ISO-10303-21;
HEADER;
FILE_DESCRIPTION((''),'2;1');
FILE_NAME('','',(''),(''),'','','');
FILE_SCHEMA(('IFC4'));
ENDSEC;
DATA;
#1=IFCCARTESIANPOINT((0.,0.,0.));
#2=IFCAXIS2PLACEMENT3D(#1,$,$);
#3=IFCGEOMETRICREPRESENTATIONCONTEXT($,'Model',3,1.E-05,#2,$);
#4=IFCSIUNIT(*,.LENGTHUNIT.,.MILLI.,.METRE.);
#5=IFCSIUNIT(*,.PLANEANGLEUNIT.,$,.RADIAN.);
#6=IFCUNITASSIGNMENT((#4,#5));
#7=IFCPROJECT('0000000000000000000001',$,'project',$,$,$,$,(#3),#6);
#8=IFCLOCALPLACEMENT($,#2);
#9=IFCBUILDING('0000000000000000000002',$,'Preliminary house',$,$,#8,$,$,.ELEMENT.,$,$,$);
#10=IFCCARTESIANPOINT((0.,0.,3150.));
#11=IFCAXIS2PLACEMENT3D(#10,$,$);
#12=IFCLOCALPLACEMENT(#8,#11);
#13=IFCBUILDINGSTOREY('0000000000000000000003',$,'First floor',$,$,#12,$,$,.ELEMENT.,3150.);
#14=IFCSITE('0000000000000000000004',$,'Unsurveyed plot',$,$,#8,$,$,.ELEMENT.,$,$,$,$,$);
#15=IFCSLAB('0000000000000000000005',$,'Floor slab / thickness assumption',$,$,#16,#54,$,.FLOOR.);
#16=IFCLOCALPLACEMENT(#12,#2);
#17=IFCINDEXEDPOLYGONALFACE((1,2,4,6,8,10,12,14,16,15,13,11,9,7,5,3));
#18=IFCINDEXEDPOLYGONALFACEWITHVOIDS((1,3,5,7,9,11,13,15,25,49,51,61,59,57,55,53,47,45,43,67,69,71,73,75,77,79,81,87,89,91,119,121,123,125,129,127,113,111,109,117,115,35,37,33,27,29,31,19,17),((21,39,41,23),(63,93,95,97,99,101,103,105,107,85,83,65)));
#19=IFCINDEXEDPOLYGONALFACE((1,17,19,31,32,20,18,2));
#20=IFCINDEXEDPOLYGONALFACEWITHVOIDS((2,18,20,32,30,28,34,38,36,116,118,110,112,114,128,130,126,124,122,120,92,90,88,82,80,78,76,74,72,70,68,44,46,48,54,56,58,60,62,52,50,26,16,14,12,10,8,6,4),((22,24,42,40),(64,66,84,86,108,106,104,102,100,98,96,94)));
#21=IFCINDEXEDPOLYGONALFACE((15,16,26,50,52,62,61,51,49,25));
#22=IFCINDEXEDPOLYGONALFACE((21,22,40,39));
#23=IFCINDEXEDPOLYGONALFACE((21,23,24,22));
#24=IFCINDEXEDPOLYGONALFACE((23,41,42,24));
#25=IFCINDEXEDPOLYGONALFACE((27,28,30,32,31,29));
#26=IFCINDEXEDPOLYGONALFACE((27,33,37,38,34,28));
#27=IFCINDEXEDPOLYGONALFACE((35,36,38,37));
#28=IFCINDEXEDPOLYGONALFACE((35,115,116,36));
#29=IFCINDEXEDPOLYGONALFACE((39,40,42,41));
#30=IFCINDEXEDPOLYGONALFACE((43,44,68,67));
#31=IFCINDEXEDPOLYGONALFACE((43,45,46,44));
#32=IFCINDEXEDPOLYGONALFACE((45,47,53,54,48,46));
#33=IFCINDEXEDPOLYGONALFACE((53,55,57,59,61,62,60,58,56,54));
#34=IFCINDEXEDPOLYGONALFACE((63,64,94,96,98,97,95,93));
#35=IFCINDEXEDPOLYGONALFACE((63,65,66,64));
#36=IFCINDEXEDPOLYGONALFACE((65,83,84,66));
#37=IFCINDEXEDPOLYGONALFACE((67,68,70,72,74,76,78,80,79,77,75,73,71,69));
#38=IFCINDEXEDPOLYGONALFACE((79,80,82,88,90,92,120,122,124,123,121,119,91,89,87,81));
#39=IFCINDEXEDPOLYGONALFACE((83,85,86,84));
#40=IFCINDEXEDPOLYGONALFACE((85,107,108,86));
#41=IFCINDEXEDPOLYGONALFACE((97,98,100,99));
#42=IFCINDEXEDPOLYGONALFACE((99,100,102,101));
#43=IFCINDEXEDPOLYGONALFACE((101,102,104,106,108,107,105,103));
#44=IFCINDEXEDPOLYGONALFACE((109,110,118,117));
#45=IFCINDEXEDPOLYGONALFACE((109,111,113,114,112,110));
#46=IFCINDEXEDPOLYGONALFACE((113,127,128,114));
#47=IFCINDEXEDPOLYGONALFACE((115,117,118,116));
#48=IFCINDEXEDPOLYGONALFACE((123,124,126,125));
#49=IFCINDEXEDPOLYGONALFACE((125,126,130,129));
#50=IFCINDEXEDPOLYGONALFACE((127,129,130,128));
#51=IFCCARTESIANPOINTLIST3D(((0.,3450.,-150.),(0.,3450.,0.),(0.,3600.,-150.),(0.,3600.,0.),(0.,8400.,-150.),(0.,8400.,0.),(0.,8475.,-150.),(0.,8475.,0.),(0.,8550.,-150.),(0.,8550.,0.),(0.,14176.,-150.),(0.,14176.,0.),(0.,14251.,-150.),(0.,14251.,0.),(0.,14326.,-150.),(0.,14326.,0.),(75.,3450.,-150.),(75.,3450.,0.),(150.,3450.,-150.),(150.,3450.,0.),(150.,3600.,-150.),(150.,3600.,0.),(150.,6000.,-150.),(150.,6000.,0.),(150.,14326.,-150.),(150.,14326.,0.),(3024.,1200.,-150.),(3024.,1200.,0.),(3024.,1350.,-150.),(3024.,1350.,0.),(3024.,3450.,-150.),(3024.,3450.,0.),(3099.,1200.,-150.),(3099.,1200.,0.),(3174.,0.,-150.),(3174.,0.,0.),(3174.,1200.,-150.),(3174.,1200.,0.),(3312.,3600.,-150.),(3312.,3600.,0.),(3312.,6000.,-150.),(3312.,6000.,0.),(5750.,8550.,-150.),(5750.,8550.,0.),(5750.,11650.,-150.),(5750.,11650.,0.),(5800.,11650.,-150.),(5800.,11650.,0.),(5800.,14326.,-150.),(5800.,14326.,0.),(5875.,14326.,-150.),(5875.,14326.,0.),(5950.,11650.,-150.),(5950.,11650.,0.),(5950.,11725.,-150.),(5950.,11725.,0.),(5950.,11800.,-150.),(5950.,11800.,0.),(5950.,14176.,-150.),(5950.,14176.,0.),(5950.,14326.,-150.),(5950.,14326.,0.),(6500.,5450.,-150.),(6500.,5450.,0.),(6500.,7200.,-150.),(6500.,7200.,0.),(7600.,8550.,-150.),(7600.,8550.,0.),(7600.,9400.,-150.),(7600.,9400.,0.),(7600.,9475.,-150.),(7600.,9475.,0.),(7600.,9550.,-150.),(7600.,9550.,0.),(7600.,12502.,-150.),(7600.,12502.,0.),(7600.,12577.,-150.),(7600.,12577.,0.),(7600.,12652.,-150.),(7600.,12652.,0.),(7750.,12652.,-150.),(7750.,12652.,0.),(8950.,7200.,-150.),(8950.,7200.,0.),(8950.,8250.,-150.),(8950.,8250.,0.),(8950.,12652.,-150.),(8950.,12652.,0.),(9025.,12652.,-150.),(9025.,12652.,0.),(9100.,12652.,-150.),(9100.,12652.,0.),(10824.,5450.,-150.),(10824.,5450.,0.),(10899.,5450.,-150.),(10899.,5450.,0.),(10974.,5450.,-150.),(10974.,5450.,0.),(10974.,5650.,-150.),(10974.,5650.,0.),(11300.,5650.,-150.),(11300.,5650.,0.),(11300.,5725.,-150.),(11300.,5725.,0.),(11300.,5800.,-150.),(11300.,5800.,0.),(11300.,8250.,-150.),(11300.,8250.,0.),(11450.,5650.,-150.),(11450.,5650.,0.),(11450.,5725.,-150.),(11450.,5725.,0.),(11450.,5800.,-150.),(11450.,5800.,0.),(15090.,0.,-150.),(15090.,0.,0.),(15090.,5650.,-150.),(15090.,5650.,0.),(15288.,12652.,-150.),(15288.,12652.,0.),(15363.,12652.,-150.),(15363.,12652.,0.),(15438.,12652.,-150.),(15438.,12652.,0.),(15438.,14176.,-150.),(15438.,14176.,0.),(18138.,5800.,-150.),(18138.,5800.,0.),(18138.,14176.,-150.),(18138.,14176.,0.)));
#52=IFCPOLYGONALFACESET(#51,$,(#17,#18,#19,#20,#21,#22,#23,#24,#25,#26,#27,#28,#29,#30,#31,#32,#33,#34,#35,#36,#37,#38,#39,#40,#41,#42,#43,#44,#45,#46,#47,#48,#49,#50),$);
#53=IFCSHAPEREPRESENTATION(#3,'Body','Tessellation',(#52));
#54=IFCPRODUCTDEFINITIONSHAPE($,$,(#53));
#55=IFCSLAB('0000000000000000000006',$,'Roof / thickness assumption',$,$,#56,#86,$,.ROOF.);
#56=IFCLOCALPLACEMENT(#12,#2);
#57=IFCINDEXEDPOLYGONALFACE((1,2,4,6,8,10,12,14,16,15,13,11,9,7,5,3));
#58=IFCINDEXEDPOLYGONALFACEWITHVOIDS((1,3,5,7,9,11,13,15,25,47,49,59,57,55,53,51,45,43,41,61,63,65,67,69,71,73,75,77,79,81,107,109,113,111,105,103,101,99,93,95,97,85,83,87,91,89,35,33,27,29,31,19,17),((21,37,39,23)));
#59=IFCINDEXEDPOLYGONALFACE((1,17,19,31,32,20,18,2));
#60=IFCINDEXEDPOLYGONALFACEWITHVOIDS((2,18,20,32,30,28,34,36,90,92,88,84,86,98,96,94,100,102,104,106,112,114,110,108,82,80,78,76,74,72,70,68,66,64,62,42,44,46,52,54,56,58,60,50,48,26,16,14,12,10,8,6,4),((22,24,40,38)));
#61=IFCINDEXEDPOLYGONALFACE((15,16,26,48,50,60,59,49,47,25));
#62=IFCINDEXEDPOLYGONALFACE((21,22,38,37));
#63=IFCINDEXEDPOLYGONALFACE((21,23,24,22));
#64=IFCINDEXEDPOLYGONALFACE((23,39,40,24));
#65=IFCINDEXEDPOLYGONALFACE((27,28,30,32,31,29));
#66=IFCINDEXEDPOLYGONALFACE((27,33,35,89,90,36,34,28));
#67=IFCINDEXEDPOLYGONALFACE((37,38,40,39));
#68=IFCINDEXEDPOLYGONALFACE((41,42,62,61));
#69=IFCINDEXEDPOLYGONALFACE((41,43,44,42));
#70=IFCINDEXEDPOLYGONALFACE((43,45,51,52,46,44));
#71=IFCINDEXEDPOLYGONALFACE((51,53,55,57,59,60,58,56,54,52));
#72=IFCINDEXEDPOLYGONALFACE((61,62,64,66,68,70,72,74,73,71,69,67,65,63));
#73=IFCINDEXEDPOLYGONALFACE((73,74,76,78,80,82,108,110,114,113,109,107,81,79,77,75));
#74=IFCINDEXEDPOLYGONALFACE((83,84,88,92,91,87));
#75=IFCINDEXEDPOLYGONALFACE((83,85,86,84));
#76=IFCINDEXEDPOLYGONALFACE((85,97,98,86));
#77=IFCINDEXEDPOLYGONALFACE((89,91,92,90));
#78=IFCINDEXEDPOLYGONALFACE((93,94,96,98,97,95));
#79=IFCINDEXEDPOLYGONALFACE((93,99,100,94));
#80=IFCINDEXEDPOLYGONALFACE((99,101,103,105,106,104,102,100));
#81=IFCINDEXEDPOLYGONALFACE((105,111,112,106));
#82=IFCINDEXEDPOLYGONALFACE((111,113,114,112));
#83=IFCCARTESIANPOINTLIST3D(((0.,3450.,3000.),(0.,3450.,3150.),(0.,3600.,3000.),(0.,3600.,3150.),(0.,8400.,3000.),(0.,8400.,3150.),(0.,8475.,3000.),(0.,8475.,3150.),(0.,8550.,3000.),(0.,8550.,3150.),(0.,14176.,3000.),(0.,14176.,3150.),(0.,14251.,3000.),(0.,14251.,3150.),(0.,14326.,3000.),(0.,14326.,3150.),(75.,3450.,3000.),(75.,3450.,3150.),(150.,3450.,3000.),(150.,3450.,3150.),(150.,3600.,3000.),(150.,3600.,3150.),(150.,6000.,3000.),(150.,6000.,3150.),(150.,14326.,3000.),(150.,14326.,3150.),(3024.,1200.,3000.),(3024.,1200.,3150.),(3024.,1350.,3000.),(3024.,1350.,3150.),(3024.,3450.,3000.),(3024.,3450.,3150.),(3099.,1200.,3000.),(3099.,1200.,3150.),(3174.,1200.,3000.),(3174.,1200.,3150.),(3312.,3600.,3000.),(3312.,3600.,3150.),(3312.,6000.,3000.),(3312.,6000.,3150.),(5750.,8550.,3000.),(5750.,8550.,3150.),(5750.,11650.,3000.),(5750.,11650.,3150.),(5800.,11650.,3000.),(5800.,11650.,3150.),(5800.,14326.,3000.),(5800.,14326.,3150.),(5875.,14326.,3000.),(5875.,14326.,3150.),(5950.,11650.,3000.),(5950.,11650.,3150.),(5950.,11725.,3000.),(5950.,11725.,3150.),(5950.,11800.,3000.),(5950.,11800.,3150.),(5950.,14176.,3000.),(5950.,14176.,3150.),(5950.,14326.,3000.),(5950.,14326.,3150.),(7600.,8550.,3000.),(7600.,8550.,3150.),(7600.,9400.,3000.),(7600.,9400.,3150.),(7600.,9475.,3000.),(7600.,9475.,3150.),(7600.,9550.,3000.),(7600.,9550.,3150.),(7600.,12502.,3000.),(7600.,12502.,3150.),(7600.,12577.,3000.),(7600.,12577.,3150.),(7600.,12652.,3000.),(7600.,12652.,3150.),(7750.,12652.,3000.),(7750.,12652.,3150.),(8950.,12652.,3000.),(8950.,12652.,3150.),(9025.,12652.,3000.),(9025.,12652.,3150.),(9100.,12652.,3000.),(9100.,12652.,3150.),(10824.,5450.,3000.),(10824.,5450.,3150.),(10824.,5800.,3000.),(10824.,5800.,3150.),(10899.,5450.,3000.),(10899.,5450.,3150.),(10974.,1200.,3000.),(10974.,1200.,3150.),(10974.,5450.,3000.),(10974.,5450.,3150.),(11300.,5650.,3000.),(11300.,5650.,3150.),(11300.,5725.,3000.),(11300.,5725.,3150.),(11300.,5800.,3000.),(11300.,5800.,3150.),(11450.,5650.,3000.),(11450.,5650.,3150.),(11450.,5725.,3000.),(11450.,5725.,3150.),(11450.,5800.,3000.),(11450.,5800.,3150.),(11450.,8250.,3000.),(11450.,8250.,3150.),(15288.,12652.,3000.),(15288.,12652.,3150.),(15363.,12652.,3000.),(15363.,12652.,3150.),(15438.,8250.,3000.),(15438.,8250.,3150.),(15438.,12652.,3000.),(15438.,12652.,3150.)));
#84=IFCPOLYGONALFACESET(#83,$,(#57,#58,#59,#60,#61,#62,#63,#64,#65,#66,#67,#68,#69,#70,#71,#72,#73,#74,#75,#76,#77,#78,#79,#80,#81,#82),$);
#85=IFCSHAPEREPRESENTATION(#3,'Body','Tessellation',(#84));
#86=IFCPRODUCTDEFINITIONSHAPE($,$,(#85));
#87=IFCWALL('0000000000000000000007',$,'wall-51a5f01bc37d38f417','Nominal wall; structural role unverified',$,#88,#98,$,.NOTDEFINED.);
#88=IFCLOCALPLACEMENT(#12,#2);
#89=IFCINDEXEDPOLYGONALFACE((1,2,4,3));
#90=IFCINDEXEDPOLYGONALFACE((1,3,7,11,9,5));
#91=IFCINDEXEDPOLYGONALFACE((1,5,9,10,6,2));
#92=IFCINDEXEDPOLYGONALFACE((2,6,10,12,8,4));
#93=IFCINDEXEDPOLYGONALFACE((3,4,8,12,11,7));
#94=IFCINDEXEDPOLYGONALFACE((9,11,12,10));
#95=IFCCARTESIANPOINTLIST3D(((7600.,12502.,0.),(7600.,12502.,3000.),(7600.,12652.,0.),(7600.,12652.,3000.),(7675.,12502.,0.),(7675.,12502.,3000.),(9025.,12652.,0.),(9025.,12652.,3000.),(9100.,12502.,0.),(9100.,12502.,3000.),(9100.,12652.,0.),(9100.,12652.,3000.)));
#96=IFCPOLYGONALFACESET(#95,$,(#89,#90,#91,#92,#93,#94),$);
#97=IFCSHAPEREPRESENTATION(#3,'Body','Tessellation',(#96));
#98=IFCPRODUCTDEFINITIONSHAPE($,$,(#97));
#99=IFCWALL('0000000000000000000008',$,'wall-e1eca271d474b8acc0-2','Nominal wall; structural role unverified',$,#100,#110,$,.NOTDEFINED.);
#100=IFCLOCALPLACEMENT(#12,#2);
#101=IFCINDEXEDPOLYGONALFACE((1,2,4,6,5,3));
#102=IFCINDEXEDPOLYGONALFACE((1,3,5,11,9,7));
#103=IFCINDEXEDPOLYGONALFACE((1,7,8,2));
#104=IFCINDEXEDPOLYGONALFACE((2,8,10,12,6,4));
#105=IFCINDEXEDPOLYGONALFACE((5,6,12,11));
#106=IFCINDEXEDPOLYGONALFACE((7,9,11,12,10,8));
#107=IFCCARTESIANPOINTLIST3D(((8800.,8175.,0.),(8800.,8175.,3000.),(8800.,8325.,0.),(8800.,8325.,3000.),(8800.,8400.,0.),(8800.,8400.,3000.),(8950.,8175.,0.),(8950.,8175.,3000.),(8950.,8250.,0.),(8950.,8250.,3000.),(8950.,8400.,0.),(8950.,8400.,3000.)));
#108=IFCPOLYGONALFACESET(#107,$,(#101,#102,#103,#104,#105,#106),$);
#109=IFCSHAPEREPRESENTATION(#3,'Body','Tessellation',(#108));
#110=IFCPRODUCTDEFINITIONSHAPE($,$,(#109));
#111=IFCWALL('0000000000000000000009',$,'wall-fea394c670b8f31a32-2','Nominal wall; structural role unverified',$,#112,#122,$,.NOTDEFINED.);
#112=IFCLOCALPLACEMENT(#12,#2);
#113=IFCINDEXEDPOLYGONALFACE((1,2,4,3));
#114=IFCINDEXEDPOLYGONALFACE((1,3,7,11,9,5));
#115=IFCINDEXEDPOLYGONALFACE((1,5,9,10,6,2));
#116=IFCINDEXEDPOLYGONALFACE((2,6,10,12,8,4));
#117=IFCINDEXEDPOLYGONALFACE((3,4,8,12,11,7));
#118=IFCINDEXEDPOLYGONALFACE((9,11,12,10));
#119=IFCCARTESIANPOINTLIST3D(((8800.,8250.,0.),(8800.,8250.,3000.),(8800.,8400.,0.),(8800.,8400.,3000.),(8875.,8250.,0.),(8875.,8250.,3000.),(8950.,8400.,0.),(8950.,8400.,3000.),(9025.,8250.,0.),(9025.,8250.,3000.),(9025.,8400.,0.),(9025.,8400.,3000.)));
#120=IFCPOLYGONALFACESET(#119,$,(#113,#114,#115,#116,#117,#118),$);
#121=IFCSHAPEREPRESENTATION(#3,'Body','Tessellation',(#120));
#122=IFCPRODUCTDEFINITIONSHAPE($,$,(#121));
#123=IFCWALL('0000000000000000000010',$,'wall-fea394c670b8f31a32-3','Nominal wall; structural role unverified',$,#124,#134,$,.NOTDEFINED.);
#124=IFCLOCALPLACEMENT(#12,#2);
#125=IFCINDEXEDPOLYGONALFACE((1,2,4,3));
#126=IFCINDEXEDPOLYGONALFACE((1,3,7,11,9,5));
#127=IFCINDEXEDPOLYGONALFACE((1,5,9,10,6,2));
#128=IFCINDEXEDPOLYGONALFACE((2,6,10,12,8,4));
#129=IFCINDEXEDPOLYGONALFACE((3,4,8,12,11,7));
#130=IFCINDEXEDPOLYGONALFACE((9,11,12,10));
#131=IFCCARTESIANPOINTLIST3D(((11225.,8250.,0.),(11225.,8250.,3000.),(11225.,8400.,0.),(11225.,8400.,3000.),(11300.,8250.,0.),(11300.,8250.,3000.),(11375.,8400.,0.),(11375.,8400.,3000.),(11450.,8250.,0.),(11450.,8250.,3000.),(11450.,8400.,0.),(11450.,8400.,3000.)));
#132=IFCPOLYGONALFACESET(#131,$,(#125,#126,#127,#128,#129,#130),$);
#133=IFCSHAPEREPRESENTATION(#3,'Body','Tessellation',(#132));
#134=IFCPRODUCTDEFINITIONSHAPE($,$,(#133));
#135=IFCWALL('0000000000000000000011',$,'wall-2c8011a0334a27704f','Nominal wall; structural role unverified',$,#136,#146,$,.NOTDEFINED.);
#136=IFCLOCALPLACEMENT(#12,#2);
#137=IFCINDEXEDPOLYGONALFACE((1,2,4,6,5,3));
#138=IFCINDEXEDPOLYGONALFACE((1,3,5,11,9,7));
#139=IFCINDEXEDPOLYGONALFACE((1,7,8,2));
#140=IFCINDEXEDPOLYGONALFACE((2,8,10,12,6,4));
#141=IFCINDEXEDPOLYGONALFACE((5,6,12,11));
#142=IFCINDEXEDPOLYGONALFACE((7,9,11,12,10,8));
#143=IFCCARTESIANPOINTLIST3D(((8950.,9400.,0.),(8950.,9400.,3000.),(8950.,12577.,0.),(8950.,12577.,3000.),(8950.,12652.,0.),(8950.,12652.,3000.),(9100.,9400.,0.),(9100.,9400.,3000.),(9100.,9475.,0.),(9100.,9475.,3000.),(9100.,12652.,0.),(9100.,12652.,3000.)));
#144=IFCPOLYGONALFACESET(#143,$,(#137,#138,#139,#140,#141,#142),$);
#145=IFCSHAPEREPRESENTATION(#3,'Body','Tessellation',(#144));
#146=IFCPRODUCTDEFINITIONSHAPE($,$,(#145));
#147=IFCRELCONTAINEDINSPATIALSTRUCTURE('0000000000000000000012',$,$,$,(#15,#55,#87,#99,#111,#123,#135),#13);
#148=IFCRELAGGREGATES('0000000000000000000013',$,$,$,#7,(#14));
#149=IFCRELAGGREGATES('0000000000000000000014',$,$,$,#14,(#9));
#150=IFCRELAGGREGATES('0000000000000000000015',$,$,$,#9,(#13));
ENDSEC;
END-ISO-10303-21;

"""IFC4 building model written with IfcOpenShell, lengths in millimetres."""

from ifc_helpers import new_model, si_unit, frame, origin, place, context, project, spatial, polyline, outline, extrude, element, save


model = new_model("IFC4")

# Units and contexts
model_context = context("Model", 3, precision=1e-05, world=origin())
ifc_project = project(units=[si_unit("LENGTHUNIT", "METRE", prefix="MILLI"), si_unit("PLANEANGLEUNIT", "RADIAN")], contexts=[model_context])

# Site, building, storey
placement_1 = place(None, origin())
site = spatial("IfcSite", under=ifc_project, at=placement_1, Name="Unsurveyed plot", CompositionType="ELEMENT")
building = spatial("IfcBuilding", under=site, at=placement_1, Name="Preliminary house", CompositionType="ELEMENT")
placement_2 = place(placement_1, frame((0.0, 0.0, 3150.0)))
storey = spatial("IfcBuildingStorey", under=building, at=placement_2, Name="First floor", CompositionType="ELEMENT", Elevation=3150.0)

# Slabs
element("IfcSlab", 1, at=placement_2, inside=storey, Name="Floor slab / thickness assumption", PredefinedType="FLOOR", context=model_context, shape_type="SweptSolid", body=[
    extrude(outline(polyline([(3024.0, 1350.0), (3024.0, 3450.0), (150.0, 3450.0), (75.0, 3450.0), (0.0, 3450.0), (0.0, 3600.0), (0.0, 8400.0), (0.0, 8475.0), (0.0, 8550.0), (0.0, 14176.0), (0.0, 14251.0), (0.0, 14326.0), (150.0, 14326.0), (5800.0, 14326.0), (5875.0, 14326.0), (5950.0, 14326.0), (5950.0, 14176.0), (5950.0, 11800.0), (5950.0, 11725.0), (5950.0, 11650.0), (5800.0, 11650.0), (5750.0, 11650.0), (5750.0, 8550.0), (7600.0, 8550.0), (7600.0, 9400.0), (7600.0, 9475.0), (7600.0, 9550.0), (7600.0, 12502.0), (7600.0, 12577.0), (7600.0, 12652.0), (7750.0, 12652.0), (8950.0, 12652.0), (9025.0, 12652.0), (9100.0, 12652.0), (15288.0, 12652.0), (15363.0, 12652.0), (15438.0, 12652.0), (15438.0, 14176.0), (18138.0, 14176.0), (18138.0, 5800.0), (11450.0, 5800.0), (11450.0, 5725.0), (11450.0, 5650.0), (15090.0, 5650.0), (15090.0, 0.0), (3174.0, 0.0), (3174.0, 1200.0), (3099.0, 1200.0), (3024.0, 1200.0), (3024.0, 1350.0)]), holes=[polyline([(10974.0, 5450.0), (10974.0, 5650.0), (11300.0, 5650.0), (11300.0, 5725.0), (11300.0, 5800.0), (11300.0, 8250.0), (8950.0, 8250.0), (8950.0, 7200.0), (6500.0, 7200.0), (6500.0, 5450.0), (10824.0, 5450.0), (10899.0, 5450.0), (10974.0, 5450.0)]), polyline([(150.0, 6000.0), (150.0, 3600.0), (3312.0, 3600.0), (3312.0, 6000.0), (150.0, 6000.0)])]), frame((0.0, 0.0, -150.0)), (0.0, 0.0, 1.0), 150.0),
])
element("IfcSlab", 2, at=placement_2, inside=storey, Name="Roof / thickness assumption", PredefinedType="ROOF", context=model_context, shape_type="SweptSolid", body=[
    extrude(outline(polyline([(3024.0, 3450.0), (150.0, 3450.0), (75.0, 3450.0), (0.0, 3450.0), (0.0, 3600.0), (0.0, 8400.0), (0.0, 8475.0), (0.0, 8550.0), (0.0, 14176.0), (0.0, 14251.0), (0.0, 14326.0), (150.0, 14326.0), (5800.0, 14326.0), (5875.0, 14326.0), (5950.0, 14326.0), (5950.0, 14176.0), (5950.0, 11800.0), (5950.0, 11725.0), (5950.0, 11650.0), (5800.0, 11650.0), (5750.0, 11650.0), (5750.0, 8550.0), (7600.0, 8550.0), (7600.0, 9400.0), (7600.0, 9475.0), (7600.0, 9550.0), (7600.0, 12502.0), (7600.0, 12577.0), (7600.0, 12652.0), (7750.0, 12652.0), (8950.0, 12652.0), (9025.0, 12652.0), (9100.0, 12652.0), (15288.0, 12652.0), (15363.0, 12652.0), (15438.0, 12652.0), (15438.0, 8250.0), (11450.0, 8250.0), (11450.0, 5800.0), (11450.0, 5725.0), (11450.0, 5650.0), (11300.0, 5650.0), (11300.0, 5725.0), (11300.0, 5800.0), (10824.0, 5800.0), (10824.0, 5450.0), (10899.0, 5450.0), (10974.0, 5450.0), (10974.0, 1200.0), (3174.0, 1200.0), (3099.0, 1200.0), (3024.0, 1200.0), (3024.0, 1350.0), (3024.0, 3450.0)]), holes=[polyline([(150.0, 6000.0), (150.0, 3600.0), (3312.0, 3600.0), (3312.0, 6000.0), (150.0, 6000.0)])]), frame((0.0, 0.0, 3000.0)), (0.0, 0.0, 1.0), 150.0),
])

# Walls
element("IfcWall", 3, at=placement_2, inside=storey, Name="wall-51a5f01bc37d38f417", Description="Nominal wall; structural role unverified", PredefinedType="NOTDEFINED", context=model_context, shape_type="SweptSolid", body=[
    extrude(outline(polyline([(9025.0, 12652.0), (9100.0, 12652.0), (9100.0, 12502.0), (7675.0, 12502.0), (7600.0, 12502.0), (7600.0, 12652.0), (9025.0, 12652.0)])), origin(), (0.0, 0.0, 1.0), 3000.0),
])
element("IfcWall", 4, at=placement_2, inside=storey, Name="wall-e1eca271d474b8acc0-2", Description="Nominal wall; structural role unverified", PredefinedType="NOTDEFINED", context=model_context, shape_type="SweptSolid", body=[
    extrude(outline(polyline([(8800.0, 8325.0), (8800.0, 8400.0), (8950.0, 8400.0), (8950.0, 8250.0), (8950.0, 8175.0), (8800.0, 8175.0), (8800.0, 8325.0)])), origin(), (0.0, 0.0, 1.0), 3000.0),
])
element("IfcWall", 5, at=placement_2, inside=storey, Name="wall-fea394c670b8f31a32-2", Description="Nominal wall; structural role unverified", PredefinedType="NOTDEFINED", context=model_context, shape_type="SweptSolid", body=[
    extrude(outline(polyline([(8950.0, 8400.0), (9025.0, 8400.0), (9025.0, 8250.0), (8875.0, 8250.0), (8800.0, 8250.0), (8800.0, 8400.0), (8950.0, 8400.0)])), origin(), (0.0, 0.0, 1.0), 3000.0),
])
element("IfcWall", 6, at=placement_2, inside=storey, Name="wall-fea394c670b8f31a32-3", Description="Nominal wall; structural role unverified", PredefinedType="NOTDEFINED", context=model_context, shape_type="SweptSolid", body=[
    extrude(outline(polyline([(11375.0, 8400.0), (11450.0, 8400.0), (11450.0, 8250.0), (11300.0, 8250.0), (11225.0, 8250.0), (11225.0, 8400.0), (11375.0, 8400.0)])), origin(), (0.0, 0.0, 1.0), 3000.0),
])
element("IfcWall", 7, at=placement_2, inside=storey, Name="wall-2c8011a0334a27704f", Description="Nominal wall; structural role unverified", PredefinedType="NOTDEFINED", context=model_context, shape_type="SweptSolid", body=[
    extrude(outline(polyline([(8950.0, 12577.0), (8950.0, 12652.0), (9100.0, 12652.0), (9100.0, 9475.0), (9100.0, 9400.0), (8950.0, 9400.0), (8950.0, 12577.0)])), origin(), (0.0, 0.0, 1.0), 3000.0),
])

save(model, "model.ifc")
